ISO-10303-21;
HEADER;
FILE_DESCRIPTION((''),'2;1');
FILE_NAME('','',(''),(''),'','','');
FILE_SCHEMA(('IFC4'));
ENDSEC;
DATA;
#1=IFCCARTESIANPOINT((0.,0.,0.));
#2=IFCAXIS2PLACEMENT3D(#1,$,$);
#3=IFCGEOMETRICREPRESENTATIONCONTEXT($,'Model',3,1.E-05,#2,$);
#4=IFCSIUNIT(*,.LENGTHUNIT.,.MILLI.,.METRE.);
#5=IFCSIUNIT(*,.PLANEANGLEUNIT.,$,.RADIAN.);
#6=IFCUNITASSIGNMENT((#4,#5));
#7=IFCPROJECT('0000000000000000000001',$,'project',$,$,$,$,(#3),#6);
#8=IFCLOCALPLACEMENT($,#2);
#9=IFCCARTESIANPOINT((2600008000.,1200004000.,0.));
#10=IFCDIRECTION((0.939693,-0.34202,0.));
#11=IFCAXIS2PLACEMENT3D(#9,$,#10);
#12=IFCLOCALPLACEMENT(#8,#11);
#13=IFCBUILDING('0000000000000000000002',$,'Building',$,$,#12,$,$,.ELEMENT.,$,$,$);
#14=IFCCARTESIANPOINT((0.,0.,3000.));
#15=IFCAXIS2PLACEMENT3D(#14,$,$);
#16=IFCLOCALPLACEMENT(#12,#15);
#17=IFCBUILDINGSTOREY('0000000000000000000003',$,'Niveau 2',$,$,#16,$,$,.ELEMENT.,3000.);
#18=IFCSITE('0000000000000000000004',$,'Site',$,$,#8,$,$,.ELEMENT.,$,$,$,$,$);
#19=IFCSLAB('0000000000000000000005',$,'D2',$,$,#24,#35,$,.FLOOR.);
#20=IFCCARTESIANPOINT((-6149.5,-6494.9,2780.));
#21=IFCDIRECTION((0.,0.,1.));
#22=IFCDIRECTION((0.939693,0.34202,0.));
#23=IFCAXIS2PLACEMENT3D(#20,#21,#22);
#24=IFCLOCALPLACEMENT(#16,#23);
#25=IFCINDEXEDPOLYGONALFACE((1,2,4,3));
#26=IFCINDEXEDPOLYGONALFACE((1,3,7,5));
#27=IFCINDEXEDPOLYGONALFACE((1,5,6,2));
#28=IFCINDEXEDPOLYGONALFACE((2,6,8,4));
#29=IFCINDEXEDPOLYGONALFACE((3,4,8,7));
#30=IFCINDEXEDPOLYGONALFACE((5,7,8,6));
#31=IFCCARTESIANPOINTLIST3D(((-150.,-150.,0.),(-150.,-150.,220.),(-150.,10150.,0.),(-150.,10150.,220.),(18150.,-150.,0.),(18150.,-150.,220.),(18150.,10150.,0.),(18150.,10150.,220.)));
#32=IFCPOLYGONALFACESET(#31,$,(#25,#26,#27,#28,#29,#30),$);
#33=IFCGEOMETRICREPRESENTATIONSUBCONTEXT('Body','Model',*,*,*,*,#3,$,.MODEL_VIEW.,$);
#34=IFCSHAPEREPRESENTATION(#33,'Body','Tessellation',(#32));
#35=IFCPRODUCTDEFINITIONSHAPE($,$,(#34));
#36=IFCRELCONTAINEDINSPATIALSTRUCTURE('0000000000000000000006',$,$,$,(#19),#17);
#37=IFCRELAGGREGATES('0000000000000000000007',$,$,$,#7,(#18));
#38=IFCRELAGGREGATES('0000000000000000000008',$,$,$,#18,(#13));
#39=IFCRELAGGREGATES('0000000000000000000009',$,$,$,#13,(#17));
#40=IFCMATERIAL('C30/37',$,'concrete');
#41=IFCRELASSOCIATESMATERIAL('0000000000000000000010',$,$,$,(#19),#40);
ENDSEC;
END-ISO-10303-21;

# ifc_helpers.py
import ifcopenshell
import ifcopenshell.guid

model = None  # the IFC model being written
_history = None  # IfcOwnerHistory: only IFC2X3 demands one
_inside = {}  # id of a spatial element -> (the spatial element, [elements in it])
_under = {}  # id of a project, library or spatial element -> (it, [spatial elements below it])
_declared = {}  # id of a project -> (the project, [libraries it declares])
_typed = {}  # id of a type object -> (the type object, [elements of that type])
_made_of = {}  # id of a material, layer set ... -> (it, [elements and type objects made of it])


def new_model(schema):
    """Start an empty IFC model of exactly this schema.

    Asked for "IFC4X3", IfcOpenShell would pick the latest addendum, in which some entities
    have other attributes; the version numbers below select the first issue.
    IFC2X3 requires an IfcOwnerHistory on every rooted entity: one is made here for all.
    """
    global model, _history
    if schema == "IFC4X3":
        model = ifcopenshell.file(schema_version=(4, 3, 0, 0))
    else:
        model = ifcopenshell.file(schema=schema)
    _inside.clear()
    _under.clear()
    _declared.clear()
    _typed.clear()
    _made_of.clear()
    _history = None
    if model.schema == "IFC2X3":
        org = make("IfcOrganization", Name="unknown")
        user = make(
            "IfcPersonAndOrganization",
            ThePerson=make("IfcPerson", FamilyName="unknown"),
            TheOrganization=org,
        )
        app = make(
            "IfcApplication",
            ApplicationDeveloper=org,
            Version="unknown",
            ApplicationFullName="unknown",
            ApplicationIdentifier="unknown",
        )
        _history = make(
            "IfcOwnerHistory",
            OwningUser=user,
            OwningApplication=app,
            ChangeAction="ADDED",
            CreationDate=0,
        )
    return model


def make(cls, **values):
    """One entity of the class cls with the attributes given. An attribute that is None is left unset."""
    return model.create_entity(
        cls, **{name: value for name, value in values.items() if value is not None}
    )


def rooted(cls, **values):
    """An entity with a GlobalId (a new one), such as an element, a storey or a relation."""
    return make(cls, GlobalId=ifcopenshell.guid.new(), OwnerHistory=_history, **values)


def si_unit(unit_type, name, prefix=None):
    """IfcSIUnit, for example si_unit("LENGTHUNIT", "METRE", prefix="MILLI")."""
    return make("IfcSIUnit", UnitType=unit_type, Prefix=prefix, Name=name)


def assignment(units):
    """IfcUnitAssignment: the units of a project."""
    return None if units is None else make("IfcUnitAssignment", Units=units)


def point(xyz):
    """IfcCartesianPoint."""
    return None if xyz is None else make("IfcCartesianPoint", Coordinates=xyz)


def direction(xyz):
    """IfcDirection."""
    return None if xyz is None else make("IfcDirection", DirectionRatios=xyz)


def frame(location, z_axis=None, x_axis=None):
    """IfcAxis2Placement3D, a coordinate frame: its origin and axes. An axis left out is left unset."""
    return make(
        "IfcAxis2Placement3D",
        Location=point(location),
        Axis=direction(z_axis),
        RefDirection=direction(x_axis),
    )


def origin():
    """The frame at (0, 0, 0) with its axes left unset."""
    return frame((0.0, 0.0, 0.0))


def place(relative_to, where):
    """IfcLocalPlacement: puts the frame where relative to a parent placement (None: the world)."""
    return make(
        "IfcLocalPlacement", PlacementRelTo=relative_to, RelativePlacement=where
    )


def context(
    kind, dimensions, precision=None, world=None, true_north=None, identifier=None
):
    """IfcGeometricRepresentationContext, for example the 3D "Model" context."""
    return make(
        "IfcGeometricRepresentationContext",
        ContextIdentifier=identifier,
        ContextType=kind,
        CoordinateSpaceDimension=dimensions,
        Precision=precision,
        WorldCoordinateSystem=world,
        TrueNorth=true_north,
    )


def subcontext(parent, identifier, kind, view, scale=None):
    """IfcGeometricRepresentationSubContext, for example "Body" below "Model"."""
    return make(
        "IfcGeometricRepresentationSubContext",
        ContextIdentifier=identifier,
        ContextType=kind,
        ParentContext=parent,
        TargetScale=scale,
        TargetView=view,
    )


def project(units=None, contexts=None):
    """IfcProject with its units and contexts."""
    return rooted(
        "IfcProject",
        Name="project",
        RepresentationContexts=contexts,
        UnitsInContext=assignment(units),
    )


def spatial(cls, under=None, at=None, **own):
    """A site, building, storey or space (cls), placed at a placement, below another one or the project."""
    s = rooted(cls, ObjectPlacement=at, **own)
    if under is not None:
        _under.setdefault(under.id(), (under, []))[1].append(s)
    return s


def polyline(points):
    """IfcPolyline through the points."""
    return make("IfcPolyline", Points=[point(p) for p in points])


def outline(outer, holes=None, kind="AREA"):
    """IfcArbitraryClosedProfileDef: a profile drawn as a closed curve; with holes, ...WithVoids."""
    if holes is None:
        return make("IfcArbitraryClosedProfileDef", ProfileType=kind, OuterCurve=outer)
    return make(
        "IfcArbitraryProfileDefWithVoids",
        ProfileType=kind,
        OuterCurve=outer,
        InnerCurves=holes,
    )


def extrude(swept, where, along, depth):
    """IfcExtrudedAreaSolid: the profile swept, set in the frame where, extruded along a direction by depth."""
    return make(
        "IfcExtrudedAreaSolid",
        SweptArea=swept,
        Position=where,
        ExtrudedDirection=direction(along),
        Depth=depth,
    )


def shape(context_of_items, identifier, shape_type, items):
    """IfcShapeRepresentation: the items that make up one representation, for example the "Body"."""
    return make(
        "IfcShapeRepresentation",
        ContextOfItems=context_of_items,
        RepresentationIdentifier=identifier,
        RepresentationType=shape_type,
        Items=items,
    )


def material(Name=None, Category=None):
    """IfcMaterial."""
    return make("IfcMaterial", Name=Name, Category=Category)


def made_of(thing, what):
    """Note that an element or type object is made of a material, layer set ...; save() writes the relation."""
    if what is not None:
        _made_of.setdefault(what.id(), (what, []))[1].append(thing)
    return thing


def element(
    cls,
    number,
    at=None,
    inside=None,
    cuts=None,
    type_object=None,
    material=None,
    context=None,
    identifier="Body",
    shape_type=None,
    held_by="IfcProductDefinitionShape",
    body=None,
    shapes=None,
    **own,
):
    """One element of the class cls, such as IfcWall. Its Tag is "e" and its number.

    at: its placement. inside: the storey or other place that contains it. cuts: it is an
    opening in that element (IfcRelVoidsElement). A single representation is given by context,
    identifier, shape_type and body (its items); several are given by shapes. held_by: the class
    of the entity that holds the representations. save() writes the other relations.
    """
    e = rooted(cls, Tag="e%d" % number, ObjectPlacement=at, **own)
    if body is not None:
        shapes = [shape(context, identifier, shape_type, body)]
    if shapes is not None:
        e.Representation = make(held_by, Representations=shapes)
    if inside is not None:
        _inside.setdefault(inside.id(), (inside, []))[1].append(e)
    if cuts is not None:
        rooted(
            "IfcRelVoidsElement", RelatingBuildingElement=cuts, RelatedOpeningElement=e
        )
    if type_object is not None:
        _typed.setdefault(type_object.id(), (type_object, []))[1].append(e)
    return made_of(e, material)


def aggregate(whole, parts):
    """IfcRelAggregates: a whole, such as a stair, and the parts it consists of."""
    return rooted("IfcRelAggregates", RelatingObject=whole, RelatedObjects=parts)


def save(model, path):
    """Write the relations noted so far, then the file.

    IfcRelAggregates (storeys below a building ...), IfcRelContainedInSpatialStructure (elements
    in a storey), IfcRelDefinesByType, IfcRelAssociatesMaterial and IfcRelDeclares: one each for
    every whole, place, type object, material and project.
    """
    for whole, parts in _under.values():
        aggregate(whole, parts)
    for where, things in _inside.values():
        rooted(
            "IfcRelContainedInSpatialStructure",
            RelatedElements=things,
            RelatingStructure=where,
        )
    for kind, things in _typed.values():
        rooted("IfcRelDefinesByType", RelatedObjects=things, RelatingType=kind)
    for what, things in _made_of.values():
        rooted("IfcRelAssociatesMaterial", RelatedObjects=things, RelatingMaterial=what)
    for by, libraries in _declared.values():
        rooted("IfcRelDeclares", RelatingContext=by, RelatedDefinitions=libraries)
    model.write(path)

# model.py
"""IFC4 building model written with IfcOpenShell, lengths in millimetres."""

from ifc_helpers import new_model, si_unit, frame, origin, place, context, subcontext, project, spatial, polyline, outline, extrude, material, element, save


model = new_model("IFC4")

# Units and contexts
model_context = context("Model", 3, precision=1e-05, world=origin())
body_context = subcontext(model_context, "Body", "Model", "MODEL_VIEW")
ifc_project = project(units=[si_unit("LENGTHUNIT", "METRE", prefix="MILLI"), si_unit("PLANEANGLEUNIT", "RADIAN")], contexts=[model_context])

# Site, building, storey
site_placement = place(None, origin())
site = spatial("IfcSite", under=ifc_project, at=site_placement, Name="Site", CompositionType="ELEMENT")
building_placement = place(site_placement, frame((2600008000.0, 1200004000.0, 0.0), x_axis=(0.939693, -0.34202, 0.0)))
building = spatial("IfcBuilding", under=site, at=building_placement, Name="Building", CompositionType="ELEMENT")
storey_placement = place(building_placement, frame((0.0, 0.0, 3000.0)))
storey = spatial("IfcBuildingStorey", under=building, at=storey_placement, Name="Niveau 2", CompositionType="ELEMENT", Elevation=3000.0)

# Shared definitions
ifc_material = material(Name="C30/37", Category="concrete")

# Slab
slab_placement = place(storey_placement, frame((-6149.5, -6494.9, 2780.0), z_axis=(0.0, 0.0, 1.0), x_axis=(0.939693, 0.34202, 0.0)))
element("IfcSlab", 1, at=slab_placement, inside=storey, material=ifc_material, Name="D2", PredefinedType="FLOOR", context=body_context, shape_type="SweptSolid", body=[
    extrude(outline(polyline([(-150.0, -150.0), (18150.0, -150.0), (18150.0, 10150.0), (-150.0, 10150.0), (-150.0, -150.0)])), origin(), (0.0, 0.0, 1.0), 220.0),
])

save(model, "model.ifc")
